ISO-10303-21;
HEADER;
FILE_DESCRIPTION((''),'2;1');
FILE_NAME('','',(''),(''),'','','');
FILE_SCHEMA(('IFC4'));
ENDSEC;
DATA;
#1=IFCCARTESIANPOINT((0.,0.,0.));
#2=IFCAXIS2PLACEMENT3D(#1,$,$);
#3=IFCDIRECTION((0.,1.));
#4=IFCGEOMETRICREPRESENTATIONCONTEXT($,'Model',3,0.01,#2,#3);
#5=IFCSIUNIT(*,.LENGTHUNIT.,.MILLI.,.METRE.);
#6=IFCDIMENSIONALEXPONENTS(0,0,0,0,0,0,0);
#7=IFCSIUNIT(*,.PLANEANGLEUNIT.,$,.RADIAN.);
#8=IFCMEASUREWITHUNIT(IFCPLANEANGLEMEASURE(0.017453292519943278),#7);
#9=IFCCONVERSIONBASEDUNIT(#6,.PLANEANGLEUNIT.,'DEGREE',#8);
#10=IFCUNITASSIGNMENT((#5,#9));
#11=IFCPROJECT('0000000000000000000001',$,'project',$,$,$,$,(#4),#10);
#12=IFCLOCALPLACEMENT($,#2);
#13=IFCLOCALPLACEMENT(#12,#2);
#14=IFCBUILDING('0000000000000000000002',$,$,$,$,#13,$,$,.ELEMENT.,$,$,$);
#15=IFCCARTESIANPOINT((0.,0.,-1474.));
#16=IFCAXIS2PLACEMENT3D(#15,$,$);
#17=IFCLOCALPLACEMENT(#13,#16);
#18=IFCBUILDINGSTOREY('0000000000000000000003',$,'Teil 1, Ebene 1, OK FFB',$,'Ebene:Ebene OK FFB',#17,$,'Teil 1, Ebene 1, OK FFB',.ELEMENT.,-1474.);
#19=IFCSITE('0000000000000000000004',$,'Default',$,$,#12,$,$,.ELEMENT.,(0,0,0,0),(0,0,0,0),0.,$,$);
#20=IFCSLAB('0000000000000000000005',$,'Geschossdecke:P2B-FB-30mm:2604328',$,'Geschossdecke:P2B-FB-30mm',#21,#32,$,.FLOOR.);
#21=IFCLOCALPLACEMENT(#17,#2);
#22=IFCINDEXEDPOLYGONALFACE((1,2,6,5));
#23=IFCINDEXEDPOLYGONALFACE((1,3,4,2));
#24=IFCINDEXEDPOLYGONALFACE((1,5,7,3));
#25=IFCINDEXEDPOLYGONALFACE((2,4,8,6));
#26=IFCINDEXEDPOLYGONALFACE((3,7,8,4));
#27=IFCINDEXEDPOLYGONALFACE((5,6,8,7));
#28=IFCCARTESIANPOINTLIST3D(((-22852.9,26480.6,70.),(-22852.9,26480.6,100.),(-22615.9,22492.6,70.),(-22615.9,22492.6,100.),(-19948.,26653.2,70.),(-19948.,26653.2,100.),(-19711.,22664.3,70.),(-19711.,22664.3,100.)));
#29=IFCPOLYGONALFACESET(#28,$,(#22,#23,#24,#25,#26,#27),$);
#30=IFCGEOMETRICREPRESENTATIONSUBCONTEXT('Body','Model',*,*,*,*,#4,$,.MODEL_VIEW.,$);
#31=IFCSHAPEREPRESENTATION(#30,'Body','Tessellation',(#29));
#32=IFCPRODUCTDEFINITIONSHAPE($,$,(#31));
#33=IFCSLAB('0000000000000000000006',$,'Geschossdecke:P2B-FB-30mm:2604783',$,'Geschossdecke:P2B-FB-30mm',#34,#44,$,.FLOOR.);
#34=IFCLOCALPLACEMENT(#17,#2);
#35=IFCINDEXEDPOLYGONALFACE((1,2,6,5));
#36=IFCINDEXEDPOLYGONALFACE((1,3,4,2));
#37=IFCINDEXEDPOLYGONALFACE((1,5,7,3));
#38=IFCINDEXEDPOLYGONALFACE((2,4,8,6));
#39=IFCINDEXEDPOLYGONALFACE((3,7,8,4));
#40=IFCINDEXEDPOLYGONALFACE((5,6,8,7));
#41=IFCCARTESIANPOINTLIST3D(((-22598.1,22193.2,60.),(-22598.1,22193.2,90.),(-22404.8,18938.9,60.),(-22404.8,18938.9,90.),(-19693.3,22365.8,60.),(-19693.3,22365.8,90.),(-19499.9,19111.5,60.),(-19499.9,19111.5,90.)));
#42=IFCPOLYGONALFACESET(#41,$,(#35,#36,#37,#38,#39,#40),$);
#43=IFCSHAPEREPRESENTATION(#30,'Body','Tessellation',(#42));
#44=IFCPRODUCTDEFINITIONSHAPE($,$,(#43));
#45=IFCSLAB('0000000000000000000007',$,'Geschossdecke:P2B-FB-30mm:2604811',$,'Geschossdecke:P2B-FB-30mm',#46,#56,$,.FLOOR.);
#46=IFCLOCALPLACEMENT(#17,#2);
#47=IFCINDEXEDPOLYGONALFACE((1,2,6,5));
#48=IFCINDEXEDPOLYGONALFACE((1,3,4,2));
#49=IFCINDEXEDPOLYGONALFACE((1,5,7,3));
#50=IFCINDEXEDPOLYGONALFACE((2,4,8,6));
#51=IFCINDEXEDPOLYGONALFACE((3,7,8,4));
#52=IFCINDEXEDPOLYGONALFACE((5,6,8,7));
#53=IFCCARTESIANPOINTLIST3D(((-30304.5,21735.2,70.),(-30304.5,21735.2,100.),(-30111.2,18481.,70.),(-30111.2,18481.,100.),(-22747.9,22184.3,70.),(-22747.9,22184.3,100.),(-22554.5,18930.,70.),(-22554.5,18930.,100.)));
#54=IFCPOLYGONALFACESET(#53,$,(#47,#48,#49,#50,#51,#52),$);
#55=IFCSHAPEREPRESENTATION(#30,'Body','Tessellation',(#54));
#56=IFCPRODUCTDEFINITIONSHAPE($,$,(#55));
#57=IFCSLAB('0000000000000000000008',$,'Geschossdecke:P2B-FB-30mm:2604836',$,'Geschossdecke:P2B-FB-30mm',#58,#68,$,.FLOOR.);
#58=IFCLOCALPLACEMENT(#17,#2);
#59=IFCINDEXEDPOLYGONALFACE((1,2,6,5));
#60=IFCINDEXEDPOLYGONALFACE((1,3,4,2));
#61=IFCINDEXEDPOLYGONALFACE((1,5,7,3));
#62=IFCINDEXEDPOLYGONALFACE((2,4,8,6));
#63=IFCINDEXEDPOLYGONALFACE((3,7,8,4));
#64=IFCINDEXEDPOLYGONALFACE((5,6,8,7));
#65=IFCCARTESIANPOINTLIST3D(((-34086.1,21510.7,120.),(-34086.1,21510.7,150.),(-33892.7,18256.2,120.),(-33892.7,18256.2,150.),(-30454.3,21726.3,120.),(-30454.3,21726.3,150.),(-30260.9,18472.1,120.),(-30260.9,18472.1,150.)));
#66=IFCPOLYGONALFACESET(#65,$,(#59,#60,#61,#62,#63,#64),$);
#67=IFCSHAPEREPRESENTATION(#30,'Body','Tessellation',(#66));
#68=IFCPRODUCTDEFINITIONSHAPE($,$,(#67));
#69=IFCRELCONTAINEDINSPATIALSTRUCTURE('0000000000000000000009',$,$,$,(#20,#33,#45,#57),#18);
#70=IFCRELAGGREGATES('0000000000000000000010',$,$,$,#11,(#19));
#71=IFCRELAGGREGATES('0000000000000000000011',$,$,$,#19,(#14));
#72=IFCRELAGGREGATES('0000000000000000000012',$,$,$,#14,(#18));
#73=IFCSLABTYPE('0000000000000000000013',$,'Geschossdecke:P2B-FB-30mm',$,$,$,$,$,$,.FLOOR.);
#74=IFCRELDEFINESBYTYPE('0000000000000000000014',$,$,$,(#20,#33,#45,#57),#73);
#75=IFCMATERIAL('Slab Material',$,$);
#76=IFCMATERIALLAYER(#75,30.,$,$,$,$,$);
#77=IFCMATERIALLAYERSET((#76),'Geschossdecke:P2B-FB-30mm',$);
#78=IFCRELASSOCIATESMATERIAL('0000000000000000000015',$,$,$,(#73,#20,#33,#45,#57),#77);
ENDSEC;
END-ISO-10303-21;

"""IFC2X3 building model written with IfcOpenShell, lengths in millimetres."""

from ifc_helpers import new_model, entity, si_unit, converted_unit, direction, frame, frame_2d, origin, place, context, subcontext, project, spatial, polyline, rectangle, outline, extrude, material, layer, layer_set, layer_usage, type_object, element, save


model = new_model("IFC2X3")

# Units and contexts
model_context = context("Model", 3, precision=0.01, world=origin(), true_north=direction((0.0, 1.0)))
body_context = subcontext(model_context, "Body", "Model", "MODEL_VIEW")
ifc_project = project(units=[si_unit("LENGTHUNIT", "METRE", prefix="MILLI"), converted_unit("PLANEANGLEUNIT", "DEGREE", entity("IfcPlaneAngleMeasure", 0.017453292519943278), si_unit("PLANEANGLEUNIT", "RADIAN"), dimensions=[0, 0, 0, 0, 0, 0, 0])], contexts=[model_context])

# Site, building, storey
site_placement = place(None, origin())
site = spatial("IfcSite", under=ifc_project, at=site_placement, Name="Default", CompositionType="ELEMENT", RefLatitude=(0, 0, 0, 0), RefLongitude=(0, 0, 0, 0), RefElevation=0.0)
building_placement = place(site_placement, origin())
building = spatial("IfcBuilding", under=site, at=building_placement, CompositionType="ELEMENT")
storey_placement = place(building_placement, frame((0.0, 0.0, -1474.0)))
storey = spatial("IfcBuildingStorey", under=building, at=storey_placement, Name="Teil 1, Ebene 1, OK FFB", ObjectType="Ebene:Ebene OK FFB", LongName="Teil 1, Ebene 1, OK FFB", CompositionType="ELEMENT", Elevation=-1474.0)

# Slabs
ifc_material_1 = material(Name="Slab Material")
ifc_layer = layer(ifc_material_1, 30.0)
ifc_layer_set = layer_set([ifc_layer], Name="Geschossdecke:P2B-FB-30mm")
slab_type = type_object("IfcSlabType", Name="Geschossdecke:P2B-FB-30mm", PredefinedType="FLOOR", material=ifc_layer_set)
ifc_layer_usage_1 = layer_usage(ifc_layer_set, "AXIS3", "POSITIVE", 0.0)
slab_1_placement = place(storey_placement, origin())
element("IfcSlab", 1, at=slab_1_placement, inside=storey, type_object=slab_type, material=ifc_layer_usage_1, Name="Geschossdecke:P2B-FB-30mm:2604328", ObjectType="Geschossdecke:P2B-FB-30mm", PredefinedType="FLOOR", context=body_context, shape_type="SweptSolid", body=[
    extrude(outline(polyline([(-1997.7, -1455.0), (1998.2, -1455.0), (1997.3, 1455.0), (-1997.7, 1455.0), (-1997.7, -1455.0)])), frame((-21282.0, 24572.7, 100.0), z_axis=(0.0, 0.0, -1.0), x_axis=(0.059319, -0.998239, 0.0)), (0.0, 0.0, 1.0), 30.0),
])
ifc_layer_usage_2 = layer_usage(ifc_layer_set, "AXIS3", "POSITIVE", 0.0)
slab_2_placement = place(storey_placement, origin())
element("IfcSlab", 2, at=slab_2_placement, inside=storey, type_object=slab_type, material=ifc_layer_usage_2, Name="Geschossdecke:P2B-FB-30mm:2604783", ObjectType="Geschossdecke:P2B-FB-30mm", PredefinedType="FLOOR", context=body_context, shape_type="SweptSolid", body=[
    extrude(rectangle(XDim=3260.0, YDim=2910.0, at=frame_2d((0.0, 0.0), x_axis=(1.0, 0.0))), frame((-21049.0, 20652.3, 90.0), z_axis=(0.0, 0.0, -1.0), x_axis=(0.059319, -0.998239, 0.0)), (0.0, 0.0, 1.0), 30.0),
])
ifc_layer_usage_3 = layer_usage(ifc_layer_set, "AXIS3", "POSITIVE", 0.0)
slab_3_placement = place(storey_placement, origin())
element("IfcSlab", 3, at=slab_3_placement, inside=storey, type_object=slab_type, material=ifc_layer_usage_3, Name="Geschossdecke:P2B-FB-30mm:2604811", ObjectType="Geschossdecke:P2B-FB-30mm", PredefinedType="FLOOR", context=body_context, shape_type="SweptSolid", body=[
    extrude(rectangle(XDim=7570.0, YDim=3260.0, at=frame_2d((0.0, 0.0), x_axis=(1.0, 0.0))), frame((-26429.5, 20332.6, 100.0), z_axis=(0.0, 0.0, -1.0), x_axis=(0.998239, 0.059319, 0.0)), (0.0, 0.0, 1.0), 30.0),
])
ifc_layer_usage_4 = layer_usage(ifc_layer_set, "AXIS3", "POSITIVE", 0.0)
slab_4_placement = place(storey_placement, origin())
element("IfcSlab", 4, at=slab_4_placement, inside=storey, type_object=slab_type, material=ifc_layer_usage_4, Name="Geschossdecke:P2B-FB-30mm:2604836", ObjectType="Geschossdecke:P2B-FB-30mm", PredefinedType="FLOOR", context=body_context, shape_type="SweptSolid", body=[
    extrude(outline(polyline([(-1630.0, -1819.1), (1630.0, -1819.1), (1630.0, 1819.1), (-1630.1, 1819.1), (-1630.0, -1819.1)])), frame((-32173.5, 19991.3, 150.0), z_axis=(0.0, 0.0, -1.0), x_axis=(0.059319, -0.998239, 0.0)), (0.0, 0.0, 1.0), 30.0),
])

save(model, "model.ifc")
